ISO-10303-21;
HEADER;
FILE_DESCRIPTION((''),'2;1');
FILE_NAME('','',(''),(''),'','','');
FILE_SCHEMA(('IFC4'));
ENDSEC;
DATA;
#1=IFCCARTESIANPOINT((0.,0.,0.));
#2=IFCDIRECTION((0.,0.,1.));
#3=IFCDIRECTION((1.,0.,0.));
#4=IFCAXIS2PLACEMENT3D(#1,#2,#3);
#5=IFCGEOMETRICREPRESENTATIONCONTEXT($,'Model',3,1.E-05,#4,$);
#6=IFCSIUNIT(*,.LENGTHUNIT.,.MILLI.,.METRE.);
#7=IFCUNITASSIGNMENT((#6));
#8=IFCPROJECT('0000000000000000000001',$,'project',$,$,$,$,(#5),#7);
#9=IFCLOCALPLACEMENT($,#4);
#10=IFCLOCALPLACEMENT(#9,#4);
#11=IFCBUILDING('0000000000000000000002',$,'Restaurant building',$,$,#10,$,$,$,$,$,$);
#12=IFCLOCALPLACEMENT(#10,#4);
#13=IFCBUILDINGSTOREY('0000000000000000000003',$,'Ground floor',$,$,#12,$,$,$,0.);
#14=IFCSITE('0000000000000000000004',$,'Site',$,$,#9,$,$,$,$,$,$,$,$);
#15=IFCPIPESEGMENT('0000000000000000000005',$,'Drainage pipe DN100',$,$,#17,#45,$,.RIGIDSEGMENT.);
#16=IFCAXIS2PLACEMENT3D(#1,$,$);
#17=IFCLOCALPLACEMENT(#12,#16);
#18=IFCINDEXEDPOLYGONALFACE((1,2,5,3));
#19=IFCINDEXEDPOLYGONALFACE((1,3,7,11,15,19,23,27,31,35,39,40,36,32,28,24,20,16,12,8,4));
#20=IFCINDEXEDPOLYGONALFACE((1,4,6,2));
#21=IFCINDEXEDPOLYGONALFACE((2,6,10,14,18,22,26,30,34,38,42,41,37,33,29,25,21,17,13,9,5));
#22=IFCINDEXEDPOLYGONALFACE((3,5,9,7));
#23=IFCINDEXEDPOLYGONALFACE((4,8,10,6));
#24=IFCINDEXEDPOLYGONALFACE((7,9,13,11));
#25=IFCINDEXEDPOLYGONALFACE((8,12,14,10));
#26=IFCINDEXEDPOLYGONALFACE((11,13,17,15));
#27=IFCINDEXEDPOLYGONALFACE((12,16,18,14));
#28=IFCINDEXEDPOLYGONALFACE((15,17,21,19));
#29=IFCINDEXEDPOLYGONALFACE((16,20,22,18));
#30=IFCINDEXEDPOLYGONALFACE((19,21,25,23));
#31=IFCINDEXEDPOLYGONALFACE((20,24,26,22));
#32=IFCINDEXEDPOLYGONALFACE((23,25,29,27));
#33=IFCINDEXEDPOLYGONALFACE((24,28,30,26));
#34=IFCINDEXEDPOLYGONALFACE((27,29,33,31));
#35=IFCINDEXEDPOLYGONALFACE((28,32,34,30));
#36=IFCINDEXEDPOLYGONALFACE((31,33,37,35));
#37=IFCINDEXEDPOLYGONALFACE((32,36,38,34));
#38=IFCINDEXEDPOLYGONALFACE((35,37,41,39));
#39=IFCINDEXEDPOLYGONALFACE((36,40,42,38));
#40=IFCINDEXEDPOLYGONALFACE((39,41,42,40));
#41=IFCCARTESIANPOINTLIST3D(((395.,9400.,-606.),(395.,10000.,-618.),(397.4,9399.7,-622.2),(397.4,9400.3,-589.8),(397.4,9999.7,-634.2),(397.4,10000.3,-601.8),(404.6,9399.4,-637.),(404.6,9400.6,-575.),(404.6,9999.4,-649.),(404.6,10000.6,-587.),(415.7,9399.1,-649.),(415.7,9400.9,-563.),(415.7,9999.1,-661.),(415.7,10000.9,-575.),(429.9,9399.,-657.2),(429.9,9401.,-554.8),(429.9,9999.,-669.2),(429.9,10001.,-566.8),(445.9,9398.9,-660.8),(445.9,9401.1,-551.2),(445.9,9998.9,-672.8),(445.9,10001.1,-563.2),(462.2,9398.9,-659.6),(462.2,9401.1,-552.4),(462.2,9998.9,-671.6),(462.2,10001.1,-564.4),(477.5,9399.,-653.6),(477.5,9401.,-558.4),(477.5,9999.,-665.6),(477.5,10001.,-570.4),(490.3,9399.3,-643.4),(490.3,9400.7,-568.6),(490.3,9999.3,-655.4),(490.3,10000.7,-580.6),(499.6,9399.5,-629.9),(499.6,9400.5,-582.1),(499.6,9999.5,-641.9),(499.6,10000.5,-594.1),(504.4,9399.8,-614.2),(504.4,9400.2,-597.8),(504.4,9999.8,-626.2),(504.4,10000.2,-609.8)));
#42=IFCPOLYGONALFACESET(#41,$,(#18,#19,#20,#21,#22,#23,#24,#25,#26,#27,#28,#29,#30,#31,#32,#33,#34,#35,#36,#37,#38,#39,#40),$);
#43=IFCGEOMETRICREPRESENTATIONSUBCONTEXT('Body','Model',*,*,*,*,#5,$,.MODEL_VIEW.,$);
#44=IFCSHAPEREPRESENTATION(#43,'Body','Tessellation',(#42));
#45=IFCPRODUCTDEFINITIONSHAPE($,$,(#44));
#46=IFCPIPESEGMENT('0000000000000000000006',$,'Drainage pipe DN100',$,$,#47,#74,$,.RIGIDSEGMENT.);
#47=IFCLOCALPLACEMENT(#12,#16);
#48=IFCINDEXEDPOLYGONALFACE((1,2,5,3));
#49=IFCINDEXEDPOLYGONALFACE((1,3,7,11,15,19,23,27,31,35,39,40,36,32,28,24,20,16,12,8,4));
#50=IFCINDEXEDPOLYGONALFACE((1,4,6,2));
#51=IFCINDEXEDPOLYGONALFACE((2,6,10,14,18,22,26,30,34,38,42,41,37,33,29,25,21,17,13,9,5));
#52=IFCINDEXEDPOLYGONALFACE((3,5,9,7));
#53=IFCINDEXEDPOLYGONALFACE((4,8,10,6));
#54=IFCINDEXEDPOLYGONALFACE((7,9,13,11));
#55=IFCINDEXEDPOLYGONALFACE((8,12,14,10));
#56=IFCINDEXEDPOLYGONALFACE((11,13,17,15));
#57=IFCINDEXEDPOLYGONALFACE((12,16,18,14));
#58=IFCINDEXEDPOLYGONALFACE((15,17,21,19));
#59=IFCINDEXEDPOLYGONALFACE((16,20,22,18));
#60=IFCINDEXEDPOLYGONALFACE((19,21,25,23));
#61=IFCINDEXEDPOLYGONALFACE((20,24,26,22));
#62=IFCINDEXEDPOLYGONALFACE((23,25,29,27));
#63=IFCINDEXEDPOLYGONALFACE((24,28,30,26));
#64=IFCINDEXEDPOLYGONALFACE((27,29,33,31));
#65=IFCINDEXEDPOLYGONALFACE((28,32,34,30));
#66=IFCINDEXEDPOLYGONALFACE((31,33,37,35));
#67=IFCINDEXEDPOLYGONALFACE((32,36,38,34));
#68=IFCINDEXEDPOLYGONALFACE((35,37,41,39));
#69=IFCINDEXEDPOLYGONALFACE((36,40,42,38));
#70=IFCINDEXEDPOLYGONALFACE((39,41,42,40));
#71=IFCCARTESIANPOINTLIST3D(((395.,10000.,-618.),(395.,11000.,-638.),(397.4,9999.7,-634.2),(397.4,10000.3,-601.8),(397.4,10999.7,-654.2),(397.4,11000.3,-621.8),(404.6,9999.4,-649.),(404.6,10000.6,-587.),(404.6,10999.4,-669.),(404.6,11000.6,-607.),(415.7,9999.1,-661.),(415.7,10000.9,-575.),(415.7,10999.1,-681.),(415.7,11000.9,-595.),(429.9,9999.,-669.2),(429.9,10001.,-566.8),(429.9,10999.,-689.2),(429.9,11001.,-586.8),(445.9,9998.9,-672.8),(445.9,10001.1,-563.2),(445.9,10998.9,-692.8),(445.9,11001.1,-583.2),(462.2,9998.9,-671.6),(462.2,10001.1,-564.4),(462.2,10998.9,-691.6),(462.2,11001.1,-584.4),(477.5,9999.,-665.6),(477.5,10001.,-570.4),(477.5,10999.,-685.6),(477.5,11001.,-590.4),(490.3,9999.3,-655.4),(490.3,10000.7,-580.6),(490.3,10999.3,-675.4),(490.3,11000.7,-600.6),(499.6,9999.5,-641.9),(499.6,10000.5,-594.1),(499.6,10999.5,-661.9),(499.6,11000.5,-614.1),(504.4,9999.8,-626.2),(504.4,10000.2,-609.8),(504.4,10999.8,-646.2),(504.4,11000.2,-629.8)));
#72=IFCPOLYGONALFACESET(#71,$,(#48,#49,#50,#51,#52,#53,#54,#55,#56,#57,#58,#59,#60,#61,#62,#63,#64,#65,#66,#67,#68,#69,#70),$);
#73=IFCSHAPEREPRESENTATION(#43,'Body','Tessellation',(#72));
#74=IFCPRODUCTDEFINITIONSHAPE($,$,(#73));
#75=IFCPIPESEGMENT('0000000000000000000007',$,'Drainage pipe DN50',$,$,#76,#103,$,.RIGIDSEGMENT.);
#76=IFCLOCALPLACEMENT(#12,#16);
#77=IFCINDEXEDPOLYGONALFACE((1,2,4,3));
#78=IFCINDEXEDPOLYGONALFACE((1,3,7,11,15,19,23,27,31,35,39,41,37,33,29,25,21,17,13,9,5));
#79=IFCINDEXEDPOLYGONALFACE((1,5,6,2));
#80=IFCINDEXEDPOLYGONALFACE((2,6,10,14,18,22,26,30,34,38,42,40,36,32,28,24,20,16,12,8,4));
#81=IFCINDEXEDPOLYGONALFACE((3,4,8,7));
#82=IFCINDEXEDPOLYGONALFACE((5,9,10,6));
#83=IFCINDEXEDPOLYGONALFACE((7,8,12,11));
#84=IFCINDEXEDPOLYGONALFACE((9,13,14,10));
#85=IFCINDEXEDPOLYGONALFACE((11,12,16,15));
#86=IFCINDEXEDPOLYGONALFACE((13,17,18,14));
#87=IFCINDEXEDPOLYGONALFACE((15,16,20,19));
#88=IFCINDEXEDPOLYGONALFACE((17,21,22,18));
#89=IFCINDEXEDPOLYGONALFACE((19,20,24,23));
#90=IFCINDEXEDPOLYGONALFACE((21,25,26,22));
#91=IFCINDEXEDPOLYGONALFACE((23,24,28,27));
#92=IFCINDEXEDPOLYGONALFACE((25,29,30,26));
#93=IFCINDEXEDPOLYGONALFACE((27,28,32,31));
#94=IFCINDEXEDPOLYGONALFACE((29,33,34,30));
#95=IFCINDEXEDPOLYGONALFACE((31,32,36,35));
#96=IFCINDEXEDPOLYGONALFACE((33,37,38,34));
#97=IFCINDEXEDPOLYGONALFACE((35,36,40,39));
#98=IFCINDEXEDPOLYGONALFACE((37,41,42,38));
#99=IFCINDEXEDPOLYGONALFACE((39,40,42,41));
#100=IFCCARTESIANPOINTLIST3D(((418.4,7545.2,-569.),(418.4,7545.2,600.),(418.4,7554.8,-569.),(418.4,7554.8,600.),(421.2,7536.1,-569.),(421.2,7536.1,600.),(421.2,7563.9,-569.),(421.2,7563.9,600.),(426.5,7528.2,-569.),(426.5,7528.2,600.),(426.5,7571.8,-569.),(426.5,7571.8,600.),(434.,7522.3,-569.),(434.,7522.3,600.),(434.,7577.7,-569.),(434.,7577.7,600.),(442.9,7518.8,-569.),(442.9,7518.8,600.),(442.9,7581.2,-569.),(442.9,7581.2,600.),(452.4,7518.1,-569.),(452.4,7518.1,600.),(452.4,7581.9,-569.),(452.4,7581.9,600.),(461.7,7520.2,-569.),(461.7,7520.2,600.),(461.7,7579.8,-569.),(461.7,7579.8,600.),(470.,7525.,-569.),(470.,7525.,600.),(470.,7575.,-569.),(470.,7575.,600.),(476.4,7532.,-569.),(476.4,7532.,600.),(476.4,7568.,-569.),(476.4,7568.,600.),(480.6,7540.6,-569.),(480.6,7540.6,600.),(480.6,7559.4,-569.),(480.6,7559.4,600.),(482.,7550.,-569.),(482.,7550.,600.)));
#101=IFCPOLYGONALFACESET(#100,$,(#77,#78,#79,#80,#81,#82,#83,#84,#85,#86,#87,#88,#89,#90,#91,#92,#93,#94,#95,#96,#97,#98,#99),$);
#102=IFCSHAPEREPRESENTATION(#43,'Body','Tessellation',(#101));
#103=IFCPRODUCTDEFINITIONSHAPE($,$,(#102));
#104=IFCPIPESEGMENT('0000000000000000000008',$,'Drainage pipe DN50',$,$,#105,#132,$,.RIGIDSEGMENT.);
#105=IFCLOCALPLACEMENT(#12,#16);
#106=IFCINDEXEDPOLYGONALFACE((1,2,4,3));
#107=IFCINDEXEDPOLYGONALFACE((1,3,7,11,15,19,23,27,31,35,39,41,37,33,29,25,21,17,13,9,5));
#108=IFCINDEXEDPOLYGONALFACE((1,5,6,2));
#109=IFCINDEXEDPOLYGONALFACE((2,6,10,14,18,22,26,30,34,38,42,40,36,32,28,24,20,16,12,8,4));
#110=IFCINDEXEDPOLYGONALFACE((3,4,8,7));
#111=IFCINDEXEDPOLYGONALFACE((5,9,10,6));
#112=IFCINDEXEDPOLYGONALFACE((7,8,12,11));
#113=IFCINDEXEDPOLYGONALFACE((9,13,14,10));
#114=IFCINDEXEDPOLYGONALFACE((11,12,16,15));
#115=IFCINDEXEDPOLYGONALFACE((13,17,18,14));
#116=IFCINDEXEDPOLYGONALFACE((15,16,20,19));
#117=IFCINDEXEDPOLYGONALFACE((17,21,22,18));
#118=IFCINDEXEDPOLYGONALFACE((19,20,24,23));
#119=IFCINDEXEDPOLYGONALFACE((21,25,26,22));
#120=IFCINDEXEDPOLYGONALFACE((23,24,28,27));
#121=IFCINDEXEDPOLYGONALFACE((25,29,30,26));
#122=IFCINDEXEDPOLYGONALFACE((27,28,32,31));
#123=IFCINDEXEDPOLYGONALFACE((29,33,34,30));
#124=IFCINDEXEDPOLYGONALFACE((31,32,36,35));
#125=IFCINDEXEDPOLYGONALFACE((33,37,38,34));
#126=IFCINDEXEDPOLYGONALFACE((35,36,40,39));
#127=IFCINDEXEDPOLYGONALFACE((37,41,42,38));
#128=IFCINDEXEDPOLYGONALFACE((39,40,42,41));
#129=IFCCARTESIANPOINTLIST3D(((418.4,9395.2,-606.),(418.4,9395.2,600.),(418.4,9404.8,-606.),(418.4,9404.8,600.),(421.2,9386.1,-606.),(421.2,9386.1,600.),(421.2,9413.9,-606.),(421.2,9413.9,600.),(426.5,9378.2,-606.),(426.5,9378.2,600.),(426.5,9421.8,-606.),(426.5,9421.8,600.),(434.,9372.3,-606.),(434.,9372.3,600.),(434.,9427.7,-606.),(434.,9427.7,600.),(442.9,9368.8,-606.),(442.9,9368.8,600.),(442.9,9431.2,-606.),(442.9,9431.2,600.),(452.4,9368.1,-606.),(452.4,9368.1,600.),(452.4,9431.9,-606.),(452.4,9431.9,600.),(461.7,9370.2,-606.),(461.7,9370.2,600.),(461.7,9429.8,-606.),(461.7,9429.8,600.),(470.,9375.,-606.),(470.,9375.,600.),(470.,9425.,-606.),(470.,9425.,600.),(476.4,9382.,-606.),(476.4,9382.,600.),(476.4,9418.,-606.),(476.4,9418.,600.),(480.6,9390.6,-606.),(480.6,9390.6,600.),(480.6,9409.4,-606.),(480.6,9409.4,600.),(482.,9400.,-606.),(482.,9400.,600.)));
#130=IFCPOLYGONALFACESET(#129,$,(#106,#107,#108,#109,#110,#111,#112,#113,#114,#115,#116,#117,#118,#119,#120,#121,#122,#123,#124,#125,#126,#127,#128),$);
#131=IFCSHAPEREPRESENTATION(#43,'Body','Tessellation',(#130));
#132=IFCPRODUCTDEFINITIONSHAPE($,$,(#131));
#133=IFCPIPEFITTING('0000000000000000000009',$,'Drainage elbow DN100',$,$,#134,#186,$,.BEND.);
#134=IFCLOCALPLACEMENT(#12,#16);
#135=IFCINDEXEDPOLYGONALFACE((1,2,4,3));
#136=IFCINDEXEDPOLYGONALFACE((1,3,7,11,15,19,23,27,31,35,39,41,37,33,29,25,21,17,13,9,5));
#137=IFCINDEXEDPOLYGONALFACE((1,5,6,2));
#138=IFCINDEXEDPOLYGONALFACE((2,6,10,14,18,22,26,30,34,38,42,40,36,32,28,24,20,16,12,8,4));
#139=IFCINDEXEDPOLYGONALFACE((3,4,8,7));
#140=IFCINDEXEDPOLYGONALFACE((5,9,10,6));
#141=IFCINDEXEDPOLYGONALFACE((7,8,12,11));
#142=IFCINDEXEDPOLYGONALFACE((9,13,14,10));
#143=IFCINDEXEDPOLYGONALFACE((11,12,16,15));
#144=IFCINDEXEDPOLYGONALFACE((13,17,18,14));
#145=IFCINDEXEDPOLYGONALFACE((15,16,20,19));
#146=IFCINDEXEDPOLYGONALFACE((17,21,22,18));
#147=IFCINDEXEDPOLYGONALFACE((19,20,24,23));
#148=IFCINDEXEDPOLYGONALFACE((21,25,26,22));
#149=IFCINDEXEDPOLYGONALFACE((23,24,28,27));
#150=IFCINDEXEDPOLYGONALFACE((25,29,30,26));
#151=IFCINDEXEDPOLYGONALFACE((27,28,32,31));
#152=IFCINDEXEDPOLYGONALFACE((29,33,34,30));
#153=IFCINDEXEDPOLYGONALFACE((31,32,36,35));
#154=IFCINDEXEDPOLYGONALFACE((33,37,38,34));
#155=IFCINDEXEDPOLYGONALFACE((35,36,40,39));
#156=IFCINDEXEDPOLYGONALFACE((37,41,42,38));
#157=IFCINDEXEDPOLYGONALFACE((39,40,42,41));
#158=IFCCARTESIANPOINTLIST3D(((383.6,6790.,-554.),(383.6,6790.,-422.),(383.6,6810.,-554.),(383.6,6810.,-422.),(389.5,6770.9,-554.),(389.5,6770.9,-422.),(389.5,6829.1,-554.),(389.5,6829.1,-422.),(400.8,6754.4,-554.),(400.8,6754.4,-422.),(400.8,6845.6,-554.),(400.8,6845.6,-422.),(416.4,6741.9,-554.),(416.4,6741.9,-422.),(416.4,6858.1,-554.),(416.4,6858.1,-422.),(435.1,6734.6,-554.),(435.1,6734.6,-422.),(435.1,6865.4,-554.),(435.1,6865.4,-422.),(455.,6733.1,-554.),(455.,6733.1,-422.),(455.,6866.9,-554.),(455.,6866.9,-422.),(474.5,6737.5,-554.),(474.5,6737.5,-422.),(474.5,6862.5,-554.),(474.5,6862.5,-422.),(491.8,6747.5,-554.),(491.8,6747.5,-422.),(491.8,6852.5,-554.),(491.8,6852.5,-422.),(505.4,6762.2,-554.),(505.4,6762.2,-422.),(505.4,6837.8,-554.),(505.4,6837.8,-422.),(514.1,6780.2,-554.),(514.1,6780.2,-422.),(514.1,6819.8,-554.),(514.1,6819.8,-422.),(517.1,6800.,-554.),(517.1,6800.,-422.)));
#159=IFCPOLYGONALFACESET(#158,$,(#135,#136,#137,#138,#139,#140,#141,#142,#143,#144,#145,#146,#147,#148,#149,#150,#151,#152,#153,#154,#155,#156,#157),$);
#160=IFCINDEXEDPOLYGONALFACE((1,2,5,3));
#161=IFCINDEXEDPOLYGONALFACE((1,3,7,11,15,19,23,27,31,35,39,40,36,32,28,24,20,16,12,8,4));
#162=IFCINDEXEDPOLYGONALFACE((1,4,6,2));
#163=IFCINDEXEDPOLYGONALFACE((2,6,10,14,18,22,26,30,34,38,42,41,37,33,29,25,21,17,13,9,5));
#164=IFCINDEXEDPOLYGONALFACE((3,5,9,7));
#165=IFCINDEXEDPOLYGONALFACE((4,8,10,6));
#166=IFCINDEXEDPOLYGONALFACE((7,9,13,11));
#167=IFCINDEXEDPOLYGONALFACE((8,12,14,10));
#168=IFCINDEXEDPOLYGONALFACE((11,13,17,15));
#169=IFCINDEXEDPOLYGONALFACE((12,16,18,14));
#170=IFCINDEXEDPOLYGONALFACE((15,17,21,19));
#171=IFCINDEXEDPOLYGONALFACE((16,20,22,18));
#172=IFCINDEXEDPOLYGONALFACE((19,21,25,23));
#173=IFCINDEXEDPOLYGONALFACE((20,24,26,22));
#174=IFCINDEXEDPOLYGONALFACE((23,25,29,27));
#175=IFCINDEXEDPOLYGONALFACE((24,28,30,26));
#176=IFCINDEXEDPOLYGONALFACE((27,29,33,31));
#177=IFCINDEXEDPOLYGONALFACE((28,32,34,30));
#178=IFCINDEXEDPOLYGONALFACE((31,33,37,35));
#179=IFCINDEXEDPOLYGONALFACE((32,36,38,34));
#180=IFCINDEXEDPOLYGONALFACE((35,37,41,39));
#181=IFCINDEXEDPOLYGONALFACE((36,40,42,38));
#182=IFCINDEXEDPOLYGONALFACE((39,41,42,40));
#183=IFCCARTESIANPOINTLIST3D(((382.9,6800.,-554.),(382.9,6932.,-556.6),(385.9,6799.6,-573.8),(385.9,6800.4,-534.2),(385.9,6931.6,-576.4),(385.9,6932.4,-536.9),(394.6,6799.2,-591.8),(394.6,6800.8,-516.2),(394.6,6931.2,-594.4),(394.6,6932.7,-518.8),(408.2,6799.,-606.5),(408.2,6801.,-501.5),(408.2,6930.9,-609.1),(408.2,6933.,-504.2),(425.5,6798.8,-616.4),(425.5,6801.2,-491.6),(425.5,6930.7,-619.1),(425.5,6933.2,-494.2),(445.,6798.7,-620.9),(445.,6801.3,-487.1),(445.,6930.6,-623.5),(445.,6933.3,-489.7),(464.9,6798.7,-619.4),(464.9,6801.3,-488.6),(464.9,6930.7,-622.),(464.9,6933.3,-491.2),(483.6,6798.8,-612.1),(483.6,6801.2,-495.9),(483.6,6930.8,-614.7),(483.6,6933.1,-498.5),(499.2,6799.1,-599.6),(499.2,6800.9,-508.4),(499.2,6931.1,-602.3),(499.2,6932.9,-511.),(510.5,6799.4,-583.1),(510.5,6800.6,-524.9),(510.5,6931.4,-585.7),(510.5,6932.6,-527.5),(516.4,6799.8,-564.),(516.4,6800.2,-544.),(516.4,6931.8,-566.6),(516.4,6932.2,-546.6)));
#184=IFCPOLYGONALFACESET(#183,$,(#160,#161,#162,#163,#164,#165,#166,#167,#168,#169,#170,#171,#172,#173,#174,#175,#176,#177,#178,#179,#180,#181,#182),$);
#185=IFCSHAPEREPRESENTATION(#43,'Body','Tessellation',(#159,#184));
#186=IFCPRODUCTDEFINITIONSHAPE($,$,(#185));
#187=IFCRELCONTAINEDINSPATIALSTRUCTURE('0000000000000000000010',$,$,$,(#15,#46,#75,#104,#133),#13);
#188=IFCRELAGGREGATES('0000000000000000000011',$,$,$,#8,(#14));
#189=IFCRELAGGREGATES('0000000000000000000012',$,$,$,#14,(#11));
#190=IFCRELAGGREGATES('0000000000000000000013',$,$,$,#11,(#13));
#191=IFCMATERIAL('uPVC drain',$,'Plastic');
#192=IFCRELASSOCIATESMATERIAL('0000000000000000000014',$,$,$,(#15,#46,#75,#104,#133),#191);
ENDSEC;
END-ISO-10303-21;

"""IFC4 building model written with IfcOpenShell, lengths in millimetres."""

from ifc_helpers import new_model, si_unit, frame, origin, origin_with_axes, origin_2d, place, context, subcontext, project, spatial, circle, extrude, material, element, save


model = new_model("IFC4")

# Units and contexts
model_context = context("Model", 3, precision=1e-05, world=origin_with_axes())
body_context = subcontext(model_context, "Body", "Model", "MODEL_VIEW")
ifc_project = project(units=[si_unit("LENGTHUNIT", "METRE", prefix="MILLI")], contexts=[model_context])

# Site, building, storey
site_placement = place(None, origin_with_axes())
site = spatial("IfcSite", under=ifc_project, at=site_placement, Name="Site")
building_placement = place(site_placement, origin_with_axes())
building = spatial("IfcBuilding", under=site, at=building_placement, Name="Restaurant building")
storey_placement = place(building_placement, origin_with_axes())
storey = spatial("IfcBuildingStorey", under=building, at=storey_placement, Name="Ground floor", Elevation=0.0)

# Pipe segments
ifc_material_1 = material(Name="uPVC drain", Category="Plastic")
pipe_segment_1_placement = place(storey_placement, frame((450.0, 9400.0, -606.0)))
element("IfcPipeSegment", 1, at=pipe_segment_1_placement, inside=storey, material=ifc_material_1, Name="Drainage pipe DN100", PredefinedType="RIGIDSEGMENT", context=body_context, shape_type="SweptSolid", body=[
    extrude(circle(Radius=55.0, at=origin_2d()), frame((0.0, 0.0, 0.0), z_axis=(0.0, 0.9998, -0.019996), x_axis=(-1.0, 0.0, 0.0)), (0.0, 0.0, 1.0), 600.1),
])
pipe_segment_2_placement = place(storey_placement, frame((450.0, 10000.0, -618.0)))
element("IfcPipeSegment", 2, at=pipe_segment_2_placement, inside=storey, material=ifc_material_1, Name="Drainage pipe DN100", PredefinedType="RIGIDSEGMENT", context=body_context, shape_type="SweptSolid", body=[
    extrude(circle(Radius=55.0, at=origin_2d()), frame((0.0, 0.0, 0.0), z_axis=(0.0, 0.9998, -0.019996), x_axis=(-1.0, 0.0, 0.0)), (0.0, 0.0, 1.0), 1000.2),
])
pipe_segment_3_placement = place(storey_placement, frame((450.0, 7550.0, 600.0)))
element("IfcPipeSegment", 3, at=pipe_segment_3_placement, inside=storey, material=ifc_material_1, Name="Drainage pipe DN50", PredefinedType="RIGIDSEGMENT", context=body_context, shape_type="SweptSolid", body=[
    extrude(circle(Radius=32.0, at=origin_2d()), frame((0.0, 0.0, 0.0), z_axis=(0.0, 0.0, -1.0), x_axis=(1.0, 0.0, 0.0)), (0.0, 0.0, 1.0), 1169.0),
])
pipe_segment_4_placement = place(storey_placement, frame((450.0, 9400.0, 600.0)))
element("IfcPipeSegment", 4, at=pipe_segment_4_placement, inside=storey, material=ifc_material_1, Name="Drainage pipe DN50", PredefinedType="RIGIDSEGMENT", context=body_context, shape_type="SweptSolid", body=[
    extrude(circle(Radius=32.0, at=origin_2d()), frame((0.0, 0.0, 0.0), z_axis=(0.0, 0.0, -1.0), x_axis=(1.0, 0.0, 0.0)), (0.0, 0.0, 1.0), 1206.0),
])

# Pipe fitting
pipe_fitting_1_placement = place(storey_placement, frame((450.0, 6800.0, -554.0)))
element("IfcPipeFitting", 5, at=pipe_fitting_1_placement, inside=storey, material=ifc_material_1, Name="Drainage elbow DN100", PredefinedType="BEND", context=body_context, shape_type="SweptSolid", body=[
    extrude(circle(Radius=67.1, at=origin_2d()), origin(), (0.0, 0.0, 1.0), 132.0),
    extrude(circle(Radius=67.1, at=origin_2d()), frame((0.0, 0.0, 0.0), z_axis=(0.0, 0.9998, -0.019996), x_axis=(-1.0, 0.0, 0.0)), (0.0, 0.0, 1.0), 132.0),
])

save(model, "model.ifc")
